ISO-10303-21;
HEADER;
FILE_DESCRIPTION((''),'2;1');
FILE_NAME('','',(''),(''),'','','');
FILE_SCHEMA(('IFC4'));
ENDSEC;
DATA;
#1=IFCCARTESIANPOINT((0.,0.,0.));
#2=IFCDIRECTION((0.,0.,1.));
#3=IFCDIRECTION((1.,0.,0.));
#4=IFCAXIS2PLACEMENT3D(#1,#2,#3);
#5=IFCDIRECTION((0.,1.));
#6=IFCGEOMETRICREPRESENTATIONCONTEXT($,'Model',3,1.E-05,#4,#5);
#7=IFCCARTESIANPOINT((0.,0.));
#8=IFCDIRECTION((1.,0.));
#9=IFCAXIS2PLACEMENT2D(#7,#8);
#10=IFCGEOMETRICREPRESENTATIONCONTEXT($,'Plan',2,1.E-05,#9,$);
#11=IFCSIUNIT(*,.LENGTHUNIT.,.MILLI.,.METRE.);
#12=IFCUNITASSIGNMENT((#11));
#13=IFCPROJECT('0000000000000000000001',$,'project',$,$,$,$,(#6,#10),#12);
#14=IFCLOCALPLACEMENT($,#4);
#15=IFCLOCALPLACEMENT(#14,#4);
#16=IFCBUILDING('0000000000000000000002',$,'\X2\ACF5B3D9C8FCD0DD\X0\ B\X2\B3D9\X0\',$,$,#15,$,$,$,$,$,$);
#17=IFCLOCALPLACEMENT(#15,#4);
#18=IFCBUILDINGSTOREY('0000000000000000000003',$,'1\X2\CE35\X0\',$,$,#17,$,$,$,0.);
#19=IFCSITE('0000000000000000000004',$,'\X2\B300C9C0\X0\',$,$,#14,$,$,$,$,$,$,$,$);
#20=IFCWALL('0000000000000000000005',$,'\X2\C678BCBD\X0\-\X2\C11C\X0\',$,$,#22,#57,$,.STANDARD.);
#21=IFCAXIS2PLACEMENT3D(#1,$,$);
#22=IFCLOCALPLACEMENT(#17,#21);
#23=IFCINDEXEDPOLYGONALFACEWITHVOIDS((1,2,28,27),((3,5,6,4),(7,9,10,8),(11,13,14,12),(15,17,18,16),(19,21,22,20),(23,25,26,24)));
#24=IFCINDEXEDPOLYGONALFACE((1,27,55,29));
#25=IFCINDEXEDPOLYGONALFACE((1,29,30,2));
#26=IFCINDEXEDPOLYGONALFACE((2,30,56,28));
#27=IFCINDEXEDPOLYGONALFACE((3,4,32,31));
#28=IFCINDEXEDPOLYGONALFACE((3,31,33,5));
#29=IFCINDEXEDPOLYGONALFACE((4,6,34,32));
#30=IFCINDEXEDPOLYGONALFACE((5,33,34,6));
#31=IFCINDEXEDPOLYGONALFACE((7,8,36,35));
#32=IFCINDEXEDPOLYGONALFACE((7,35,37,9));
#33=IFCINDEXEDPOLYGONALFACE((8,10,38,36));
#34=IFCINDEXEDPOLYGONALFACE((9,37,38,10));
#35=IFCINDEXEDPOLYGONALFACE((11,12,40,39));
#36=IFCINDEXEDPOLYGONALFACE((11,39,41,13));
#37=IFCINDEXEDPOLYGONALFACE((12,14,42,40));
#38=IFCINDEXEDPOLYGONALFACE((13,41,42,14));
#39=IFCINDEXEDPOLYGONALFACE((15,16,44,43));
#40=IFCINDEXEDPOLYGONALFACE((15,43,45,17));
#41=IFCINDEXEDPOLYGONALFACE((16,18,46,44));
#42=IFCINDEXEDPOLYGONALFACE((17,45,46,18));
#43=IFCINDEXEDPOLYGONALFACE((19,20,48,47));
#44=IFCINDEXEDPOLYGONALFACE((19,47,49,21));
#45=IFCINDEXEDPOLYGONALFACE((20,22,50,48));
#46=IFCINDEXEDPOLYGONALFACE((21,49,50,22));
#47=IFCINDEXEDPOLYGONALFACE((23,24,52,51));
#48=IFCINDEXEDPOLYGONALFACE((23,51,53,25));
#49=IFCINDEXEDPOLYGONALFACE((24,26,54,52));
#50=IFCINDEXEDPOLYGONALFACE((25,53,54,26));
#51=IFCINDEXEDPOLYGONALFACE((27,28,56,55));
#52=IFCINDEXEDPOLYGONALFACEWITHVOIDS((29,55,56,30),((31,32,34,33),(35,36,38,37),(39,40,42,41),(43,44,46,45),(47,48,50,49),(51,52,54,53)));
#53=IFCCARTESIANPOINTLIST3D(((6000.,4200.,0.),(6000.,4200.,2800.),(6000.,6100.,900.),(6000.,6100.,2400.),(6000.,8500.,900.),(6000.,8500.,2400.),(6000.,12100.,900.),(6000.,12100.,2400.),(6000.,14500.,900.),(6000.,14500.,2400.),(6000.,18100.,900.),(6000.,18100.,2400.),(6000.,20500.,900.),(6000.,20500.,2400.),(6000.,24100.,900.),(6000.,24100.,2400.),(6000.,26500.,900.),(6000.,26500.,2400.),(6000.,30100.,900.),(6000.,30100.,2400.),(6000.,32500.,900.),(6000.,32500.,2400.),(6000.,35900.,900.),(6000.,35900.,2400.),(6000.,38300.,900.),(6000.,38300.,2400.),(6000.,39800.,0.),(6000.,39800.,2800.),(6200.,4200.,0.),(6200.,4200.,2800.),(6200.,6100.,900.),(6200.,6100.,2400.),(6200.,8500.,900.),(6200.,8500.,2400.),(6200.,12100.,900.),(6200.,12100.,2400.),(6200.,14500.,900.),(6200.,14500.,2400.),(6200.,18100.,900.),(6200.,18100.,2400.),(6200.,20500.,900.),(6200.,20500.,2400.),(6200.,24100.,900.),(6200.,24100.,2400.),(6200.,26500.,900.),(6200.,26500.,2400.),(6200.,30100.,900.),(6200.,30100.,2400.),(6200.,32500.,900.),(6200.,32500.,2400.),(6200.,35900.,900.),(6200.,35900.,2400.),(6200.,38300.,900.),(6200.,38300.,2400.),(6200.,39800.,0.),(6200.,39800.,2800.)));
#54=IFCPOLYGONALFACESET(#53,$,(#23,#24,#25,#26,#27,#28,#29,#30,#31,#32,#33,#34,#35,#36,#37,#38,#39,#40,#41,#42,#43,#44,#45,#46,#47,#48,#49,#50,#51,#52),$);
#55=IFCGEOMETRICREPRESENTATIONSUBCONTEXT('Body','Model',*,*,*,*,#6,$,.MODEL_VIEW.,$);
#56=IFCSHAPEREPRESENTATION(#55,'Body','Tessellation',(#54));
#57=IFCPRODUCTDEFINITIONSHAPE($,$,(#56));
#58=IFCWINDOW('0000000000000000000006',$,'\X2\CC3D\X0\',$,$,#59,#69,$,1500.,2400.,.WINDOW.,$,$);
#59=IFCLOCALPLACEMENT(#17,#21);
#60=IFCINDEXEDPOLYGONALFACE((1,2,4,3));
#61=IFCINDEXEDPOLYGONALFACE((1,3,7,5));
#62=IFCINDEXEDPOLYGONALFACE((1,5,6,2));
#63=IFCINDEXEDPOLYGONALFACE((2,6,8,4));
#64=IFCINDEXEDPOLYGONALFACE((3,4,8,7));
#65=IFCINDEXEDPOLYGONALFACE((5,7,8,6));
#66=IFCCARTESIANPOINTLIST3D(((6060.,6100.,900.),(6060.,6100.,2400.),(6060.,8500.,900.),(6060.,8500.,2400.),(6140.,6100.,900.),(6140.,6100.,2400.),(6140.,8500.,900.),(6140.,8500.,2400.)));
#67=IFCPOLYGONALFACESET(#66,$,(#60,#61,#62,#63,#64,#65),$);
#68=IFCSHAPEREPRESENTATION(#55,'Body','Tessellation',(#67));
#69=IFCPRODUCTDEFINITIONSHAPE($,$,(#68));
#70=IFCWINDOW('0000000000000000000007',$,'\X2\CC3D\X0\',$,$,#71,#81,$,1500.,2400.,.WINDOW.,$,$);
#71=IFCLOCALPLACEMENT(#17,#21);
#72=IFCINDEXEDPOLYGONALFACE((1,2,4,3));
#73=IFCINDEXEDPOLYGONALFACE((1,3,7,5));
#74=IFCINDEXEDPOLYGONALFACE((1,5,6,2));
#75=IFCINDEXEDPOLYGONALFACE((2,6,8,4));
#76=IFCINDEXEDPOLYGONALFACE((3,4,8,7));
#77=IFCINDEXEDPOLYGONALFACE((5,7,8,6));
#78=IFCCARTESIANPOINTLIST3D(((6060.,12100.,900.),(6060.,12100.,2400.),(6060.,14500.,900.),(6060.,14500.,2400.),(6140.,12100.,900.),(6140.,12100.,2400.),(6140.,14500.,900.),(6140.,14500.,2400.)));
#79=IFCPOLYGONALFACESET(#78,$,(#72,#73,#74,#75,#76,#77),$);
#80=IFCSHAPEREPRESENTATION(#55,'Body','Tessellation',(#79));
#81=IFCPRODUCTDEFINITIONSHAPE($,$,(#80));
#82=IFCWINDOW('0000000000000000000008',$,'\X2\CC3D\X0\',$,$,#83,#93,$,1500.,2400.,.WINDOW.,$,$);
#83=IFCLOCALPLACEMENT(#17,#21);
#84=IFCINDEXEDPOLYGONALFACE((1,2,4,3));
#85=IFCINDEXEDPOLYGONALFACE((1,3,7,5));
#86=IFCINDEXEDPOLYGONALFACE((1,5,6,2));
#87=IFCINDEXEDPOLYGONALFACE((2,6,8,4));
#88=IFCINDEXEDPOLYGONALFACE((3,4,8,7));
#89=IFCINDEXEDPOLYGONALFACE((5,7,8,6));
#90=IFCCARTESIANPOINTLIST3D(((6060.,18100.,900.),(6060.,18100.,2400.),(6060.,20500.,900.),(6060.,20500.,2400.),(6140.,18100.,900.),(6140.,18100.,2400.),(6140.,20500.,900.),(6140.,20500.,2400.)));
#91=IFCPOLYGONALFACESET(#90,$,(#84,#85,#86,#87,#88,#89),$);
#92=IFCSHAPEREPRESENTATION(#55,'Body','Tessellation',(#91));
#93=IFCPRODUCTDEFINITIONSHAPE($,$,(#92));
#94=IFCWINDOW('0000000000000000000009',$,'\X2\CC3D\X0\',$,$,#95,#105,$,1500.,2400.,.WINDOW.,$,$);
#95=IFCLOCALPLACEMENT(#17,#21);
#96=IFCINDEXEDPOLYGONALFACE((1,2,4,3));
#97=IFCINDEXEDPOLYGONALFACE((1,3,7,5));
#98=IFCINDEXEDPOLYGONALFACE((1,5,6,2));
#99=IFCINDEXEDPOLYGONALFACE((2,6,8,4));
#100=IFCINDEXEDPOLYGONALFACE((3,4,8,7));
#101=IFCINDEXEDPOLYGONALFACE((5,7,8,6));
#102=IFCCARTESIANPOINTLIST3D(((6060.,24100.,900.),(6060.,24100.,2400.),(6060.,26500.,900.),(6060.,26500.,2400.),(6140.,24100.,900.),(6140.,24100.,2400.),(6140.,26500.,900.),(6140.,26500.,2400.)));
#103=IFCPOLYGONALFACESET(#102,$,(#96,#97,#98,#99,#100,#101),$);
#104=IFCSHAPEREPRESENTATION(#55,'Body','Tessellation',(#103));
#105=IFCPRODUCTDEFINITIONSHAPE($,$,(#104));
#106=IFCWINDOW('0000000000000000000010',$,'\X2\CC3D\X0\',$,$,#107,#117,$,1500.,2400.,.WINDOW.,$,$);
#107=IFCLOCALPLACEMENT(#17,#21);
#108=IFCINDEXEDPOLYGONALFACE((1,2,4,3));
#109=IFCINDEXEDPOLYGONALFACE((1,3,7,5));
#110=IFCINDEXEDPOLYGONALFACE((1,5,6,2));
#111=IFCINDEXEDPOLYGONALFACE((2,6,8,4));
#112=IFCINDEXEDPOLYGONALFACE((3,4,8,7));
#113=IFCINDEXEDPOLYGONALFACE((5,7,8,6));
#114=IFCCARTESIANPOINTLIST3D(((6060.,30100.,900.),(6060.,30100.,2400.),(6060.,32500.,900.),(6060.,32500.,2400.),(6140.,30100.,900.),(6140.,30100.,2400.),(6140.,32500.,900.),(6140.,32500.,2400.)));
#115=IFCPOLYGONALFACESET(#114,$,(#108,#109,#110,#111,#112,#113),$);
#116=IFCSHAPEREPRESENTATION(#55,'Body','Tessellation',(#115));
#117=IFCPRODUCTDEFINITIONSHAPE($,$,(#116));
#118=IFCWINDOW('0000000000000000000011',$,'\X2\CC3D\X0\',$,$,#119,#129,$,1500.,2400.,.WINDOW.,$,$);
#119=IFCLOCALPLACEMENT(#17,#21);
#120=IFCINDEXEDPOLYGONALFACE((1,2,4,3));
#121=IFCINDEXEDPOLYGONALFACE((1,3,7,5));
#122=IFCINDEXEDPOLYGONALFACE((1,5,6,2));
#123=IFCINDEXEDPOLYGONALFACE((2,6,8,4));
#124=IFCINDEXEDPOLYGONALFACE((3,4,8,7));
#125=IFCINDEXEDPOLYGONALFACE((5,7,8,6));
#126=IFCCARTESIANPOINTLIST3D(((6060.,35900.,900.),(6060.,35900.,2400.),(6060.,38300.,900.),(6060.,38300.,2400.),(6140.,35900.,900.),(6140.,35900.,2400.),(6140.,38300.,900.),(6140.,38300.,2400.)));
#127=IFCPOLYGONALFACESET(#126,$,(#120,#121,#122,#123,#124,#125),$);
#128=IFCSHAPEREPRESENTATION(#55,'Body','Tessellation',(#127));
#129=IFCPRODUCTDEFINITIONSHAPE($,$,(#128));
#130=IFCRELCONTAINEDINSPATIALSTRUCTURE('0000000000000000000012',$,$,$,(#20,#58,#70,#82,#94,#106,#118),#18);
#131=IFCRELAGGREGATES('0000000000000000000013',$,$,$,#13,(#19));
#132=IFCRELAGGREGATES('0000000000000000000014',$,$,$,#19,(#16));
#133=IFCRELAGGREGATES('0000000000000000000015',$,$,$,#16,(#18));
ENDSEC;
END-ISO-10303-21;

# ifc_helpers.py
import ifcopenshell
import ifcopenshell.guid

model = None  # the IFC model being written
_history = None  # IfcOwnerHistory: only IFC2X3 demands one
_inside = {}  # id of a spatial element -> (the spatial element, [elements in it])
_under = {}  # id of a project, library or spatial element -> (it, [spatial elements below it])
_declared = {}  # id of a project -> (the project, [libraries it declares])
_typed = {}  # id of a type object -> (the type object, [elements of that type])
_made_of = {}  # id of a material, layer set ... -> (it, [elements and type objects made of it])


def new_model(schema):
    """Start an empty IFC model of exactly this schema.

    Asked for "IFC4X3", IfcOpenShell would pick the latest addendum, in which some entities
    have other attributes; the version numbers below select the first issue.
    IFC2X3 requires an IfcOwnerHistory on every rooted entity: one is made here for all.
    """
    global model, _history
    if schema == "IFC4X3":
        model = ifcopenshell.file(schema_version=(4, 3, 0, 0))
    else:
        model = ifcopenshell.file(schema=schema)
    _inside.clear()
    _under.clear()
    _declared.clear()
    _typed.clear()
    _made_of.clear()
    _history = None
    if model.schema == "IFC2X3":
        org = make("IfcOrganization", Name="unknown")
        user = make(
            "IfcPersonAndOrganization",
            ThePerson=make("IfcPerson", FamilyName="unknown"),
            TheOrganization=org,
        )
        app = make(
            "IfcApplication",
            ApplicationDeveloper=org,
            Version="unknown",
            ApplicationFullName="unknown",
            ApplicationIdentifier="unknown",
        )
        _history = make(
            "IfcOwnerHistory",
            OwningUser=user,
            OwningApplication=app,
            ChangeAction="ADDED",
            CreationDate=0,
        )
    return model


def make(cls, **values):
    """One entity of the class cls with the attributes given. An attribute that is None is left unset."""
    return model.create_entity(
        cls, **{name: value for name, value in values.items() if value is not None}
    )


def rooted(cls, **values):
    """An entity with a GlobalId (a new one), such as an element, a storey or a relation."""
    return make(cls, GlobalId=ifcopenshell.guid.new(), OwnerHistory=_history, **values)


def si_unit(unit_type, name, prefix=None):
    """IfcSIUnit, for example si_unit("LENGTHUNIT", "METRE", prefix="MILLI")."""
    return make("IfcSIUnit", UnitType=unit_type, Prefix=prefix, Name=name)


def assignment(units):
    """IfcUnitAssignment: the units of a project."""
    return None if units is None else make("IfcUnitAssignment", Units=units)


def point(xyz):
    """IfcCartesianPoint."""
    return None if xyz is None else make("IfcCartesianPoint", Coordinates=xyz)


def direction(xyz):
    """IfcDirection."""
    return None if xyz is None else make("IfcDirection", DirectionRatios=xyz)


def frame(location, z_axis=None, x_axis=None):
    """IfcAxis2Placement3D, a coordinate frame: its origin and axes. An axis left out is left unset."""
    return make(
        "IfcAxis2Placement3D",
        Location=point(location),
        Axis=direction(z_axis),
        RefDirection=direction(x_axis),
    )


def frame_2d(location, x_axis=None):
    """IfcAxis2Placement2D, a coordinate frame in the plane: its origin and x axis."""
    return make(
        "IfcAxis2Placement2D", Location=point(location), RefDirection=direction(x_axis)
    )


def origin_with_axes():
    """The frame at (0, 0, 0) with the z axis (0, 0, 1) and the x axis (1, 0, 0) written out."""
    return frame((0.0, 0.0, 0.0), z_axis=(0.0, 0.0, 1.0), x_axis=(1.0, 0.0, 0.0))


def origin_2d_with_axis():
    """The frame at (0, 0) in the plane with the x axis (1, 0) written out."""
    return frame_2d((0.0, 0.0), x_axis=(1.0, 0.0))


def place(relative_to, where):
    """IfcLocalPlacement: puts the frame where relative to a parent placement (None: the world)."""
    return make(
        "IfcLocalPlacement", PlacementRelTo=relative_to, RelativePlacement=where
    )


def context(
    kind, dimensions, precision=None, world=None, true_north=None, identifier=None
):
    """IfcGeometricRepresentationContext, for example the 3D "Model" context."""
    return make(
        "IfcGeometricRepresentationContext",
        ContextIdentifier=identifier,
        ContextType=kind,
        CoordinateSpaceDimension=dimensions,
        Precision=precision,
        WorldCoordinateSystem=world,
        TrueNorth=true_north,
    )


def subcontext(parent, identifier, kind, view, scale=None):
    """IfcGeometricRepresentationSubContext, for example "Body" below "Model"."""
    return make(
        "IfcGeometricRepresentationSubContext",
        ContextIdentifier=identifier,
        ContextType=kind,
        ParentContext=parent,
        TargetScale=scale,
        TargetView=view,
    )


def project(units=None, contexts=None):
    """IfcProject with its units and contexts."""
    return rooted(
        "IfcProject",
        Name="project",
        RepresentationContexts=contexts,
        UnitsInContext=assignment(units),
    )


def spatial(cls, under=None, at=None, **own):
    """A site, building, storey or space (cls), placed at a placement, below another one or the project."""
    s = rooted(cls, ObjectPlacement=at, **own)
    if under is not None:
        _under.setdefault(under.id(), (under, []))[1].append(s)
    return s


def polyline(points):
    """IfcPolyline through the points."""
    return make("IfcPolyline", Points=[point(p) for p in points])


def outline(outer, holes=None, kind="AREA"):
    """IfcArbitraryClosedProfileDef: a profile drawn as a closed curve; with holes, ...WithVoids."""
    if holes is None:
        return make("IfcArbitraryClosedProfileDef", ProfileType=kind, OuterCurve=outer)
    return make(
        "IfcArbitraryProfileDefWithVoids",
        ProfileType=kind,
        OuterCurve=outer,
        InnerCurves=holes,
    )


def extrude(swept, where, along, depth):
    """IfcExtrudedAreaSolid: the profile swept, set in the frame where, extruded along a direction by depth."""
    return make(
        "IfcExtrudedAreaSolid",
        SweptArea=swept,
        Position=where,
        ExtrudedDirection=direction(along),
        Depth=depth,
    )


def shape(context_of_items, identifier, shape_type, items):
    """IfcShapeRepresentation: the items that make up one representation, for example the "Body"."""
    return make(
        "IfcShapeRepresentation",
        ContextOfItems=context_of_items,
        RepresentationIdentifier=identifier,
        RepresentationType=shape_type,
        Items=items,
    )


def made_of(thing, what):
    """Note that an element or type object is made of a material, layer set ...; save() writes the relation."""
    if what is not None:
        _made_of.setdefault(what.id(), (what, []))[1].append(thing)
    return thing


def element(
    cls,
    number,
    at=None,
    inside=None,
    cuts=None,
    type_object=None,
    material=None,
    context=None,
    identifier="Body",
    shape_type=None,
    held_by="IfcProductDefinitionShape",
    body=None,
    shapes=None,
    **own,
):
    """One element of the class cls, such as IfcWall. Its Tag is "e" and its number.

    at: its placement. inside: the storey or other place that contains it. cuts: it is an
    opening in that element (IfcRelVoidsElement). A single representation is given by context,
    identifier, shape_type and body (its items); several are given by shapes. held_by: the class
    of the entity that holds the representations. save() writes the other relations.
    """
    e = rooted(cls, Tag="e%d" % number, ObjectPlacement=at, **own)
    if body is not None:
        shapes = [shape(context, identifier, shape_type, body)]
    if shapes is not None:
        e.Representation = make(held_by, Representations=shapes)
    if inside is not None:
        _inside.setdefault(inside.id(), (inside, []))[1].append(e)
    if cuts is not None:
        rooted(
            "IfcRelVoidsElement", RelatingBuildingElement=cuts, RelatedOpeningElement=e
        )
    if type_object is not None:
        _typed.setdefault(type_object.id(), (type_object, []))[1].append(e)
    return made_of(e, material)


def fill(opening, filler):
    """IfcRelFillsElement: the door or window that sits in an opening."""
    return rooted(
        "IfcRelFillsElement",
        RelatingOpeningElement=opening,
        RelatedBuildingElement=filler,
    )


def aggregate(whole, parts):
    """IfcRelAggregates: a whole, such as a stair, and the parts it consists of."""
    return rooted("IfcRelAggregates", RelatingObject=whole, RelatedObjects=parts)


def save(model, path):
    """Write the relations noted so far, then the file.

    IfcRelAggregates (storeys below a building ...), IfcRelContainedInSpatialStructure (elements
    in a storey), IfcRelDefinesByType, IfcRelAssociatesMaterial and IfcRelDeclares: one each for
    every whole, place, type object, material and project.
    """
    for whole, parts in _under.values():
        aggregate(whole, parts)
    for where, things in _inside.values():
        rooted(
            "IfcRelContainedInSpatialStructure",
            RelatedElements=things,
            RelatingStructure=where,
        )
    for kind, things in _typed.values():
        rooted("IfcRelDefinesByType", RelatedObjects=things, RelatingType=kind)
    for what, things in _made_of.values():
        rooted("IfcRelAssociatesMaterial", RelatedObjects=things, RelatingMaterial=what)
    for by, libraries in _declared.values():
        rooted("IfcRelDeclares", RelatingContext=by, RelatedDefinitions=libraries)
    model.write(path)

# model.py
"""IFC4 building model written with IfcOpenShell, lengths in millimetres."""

from ifc_helpers import new_model, si_unit, direction, frame, origin_with_axes, origin_2d_with_axis, place, context, subcontext, project, spatial, polyline, outline, extrude, element, fill, save


model = new_model("IFC4")

# Units and contexts
model_context = context("Model", 3, precision=1e-05, world=origin_with_axes(), true_north=direction((0.0, 1.0)))
plan_context = context("Plan", 2, precision=1e-05, world=origin_2d_with_axis())
body_context = subcontext(model_context, "Body", "Model", "MODEL_VIEW")
ifc_project = project(units=[si_unit("LENGTHUNIT", "METRE", prefix="MILLI")], contexts=[model_context, plan_context])

# Site, building, storey
site_placement = place(None, origin_with_axes())
site = spatial("IfcSite", under=ifc_project, at=site_placement, Name="대지")
building_placement = place(site_placement, origin_with_axes())
building = spatial("IfcBuilding", under=site, at=building_placement, Name="공동주택 B동")
storey_placement = place(building_placement, origin_with_axes())
storey = spatial("IfcBuildingStorey", under=building, at=storey_placement, Name="1층", Elevation=0.0)

# Wall, openings, windows
wall_1_placement = place(storey_placement, origin_with_axes())
wall_1 = element("IfcWall", 1, at=wall_1_placement, inside=storey, Name="외벽-서", PredefinedType="STANDARD", context=body_context, shape_type="SweptSolid", body=[
    extrude(outline(polyline([(6200.0, 39800.0), (6200.0, 4200.0), (6000.0, 4200.0), (6000.0, 39800.0), (6200.0, 39800.0)])), origin_with_axes(), (0.0, 0.0, 1.0), 2800.0),
])
opening_1_placement = place(storey_placement, origin_with_axes())
opening_1 = element("IfcOpeningElement", 2, at=opening_1_placement, cuts=wall_1, PredefinedType="OPENING", context=body_context, shape_type="SweptSolid", body=[
    extrude(outline(polyline([(5950.0, 8500.0), (5950.0, 6100.0), (6250.0, 6100.0), (6250.0, 8500.0), (5950.0, 8500.0)])), frame((0.0, 0.0, 900.0), z_axis=(0.0, 0.0, 1.0), x_axis=(1.0, 0.0, 0.0)), (0.0, 0.0, 1.0), 1500.0),
])
opening_2_placement = place(storey_placement, origin_with_axes())
opening_2 = element("IfcOpeningElement", 3, at=opening_2_placement, cuts=wall_1, PredefinedType="OPENING", context=body_context, shape_type="SweptSolid", body=[
    extrude(outline(polyline([(5950.0, 14500.0), (5950.0, 12100.0), (6250.0, 12100.0), (6250.0, 14500.0), (5950.0, 14500.0)])), frame((0.0, 0.0, 900.0), z_axis=(0.0, 0.0, 1.0), x_axis=(1.0, 0.0, 0.0)), (0.0, 0.0, 1.0), 1500.0),
])
opening_3_placement = place(storey_placement, origin_with_axes())
opening_3 = element("IfcOpeningElement", 4, at=opening_3_placement, cuts=wall_1, PredefinedType="OPENING", context=body_context, shape_type="SweptSolid", body=[
    extrude(outline(polyline([(5950.0, 20500.0), (5950.0, 18100.0), (6250.0, 18100.0), (6250.0, 20500.0), (5950.0, 20500.0)])), frame((0.0, 0.0, 900.0), z_axis=(0.0, 0.0, 1.0), x_axis=(1.0, 0.0, 0.0)), (0.0, 0.0, 1.0), 1500.0),
])
opening_4_placement = place(storey_placement, origin_with_axes())
opening_4 = element("IfcOpeningElement", 5, at=opening_4_placement, cuts=wall_1, PredefinedType="OPENING", context=body_context, shape_type="SweptSolid", body=[
    extrude(outline(polyline([(5950.0, 26500.0), (5950.0, 24100.0), (6250.0, 24100.0), (6250.0, 26500.0), (5950.0, 26500.0)])), frame((0.0, 0.0, 900.0), z_axis=(0.0, 0.0, 1.0), x_axis=(1.0, 0.0, 0.0)), (0.0, 0.0, 1.0), 1500.0),
])
opening_5_placement = place(storey_placement, origin_with_axes())
opening_5 = element("IfcOpeningElement", 6, at=opening_5_placement, cuts=wall_1, PredefinedType="OPENING", context=body_context, shape_type="SweptSolid", body=[
    extrude(outline(polyline([(5950.0, 32500.0), (5950.0, 30100.0), (6250.0, 30100.0), (6250.0, 32500.0), (5950.0, 32500.0)])), frame((0.0, 0.0, 900.0), z_axis=(0.0, 0.0, 1.0), x_axis=(1.0, 0.0, 0.0)), (0.0, 0.0, 1.0), 1500.0),
])
opening_6_placement = place(storey_placement, origin_with_axes())
opening_6 = element("IfcOpeningElement", 7, at=opening_6_placement, cuts=wall_1, PredefinedType="OPENING", context=body_context, shape_type="SweptSolid", body=[
    extrude(outline(polyline([(5950.0, 38300.0), (5950.0, 35900.0), (6250.0, 35900.0), (6250.0, 38300.0), (5950.0, 38300.0)])), frame((0.0, 0.0, 900.0), z_axis=(0.0, 0.0, 1.0), x_axis=(1.0, 0.0, 0.0)), (0.0, 0.0, 1.0), 1500.0),
])
window_1_placement = place(storey_placement, origin_with_axes())
window_1 = element("IfcWindow", 8, at=window_1_placement, inside=storey, Name="창", OverallHeight=1500.0, OverallWidth=2400.0, PredefinedType="WINDOW", context=body_context, shape_type="SweptSolid", body=[
    extrude(outline(polyline([(6060.0, 8500.0), (6060.0, 6100.0), (6140.0, 6100.0), (6140.0, 8500.0), (6060.0, 8500.0)])), frame((0.0, 0.0, 900.0), z_axis=(0.0, 0.0, 1.0), x_axis=(1.0, 0.0, 0.0)), (0.0, 0.0, 1.0), 1500.0),
])
fill(opening_1, window_1)
window_2_placement = place(storey_placement, origin_with_axes())
window_2 = element("IfcWindow", 9, at=window_2_placement, inside=storey, Name="창", OverallHeight=1500.0, OverallWidth=2400.0, PredefinedType="WINDOW", context=body_context, shape_type="SweptSolid", body=[
    extrude(outline(polyline([(6060.0, 14500.0), (6060.0, 12100.0), (6140.0, 12100.0), (6140.0, 14500.0), (6060.0, 14500.0)])), frame((0.0, 0.0, 900.0), z_axis=(0.0, 0.0, 1.0), x_axis=(1.0, 0.0, 0.0)), (0.0, 0.0, 1.0), 1500.0),
])
fill(opening_2, window_2)
window_3_placement = place(storey_placement, origin_with_axes())
window_3 = element("IfcWindow", 10, at=window_3_placement, inside=storey, Name="창", OverallHeight=1500.0, OverallWidth=2400.0, PredefinedType="WINDOW", context=body_context, shape_type="SweptSolid", body=[
    extrude(outline(polyline([(6060.0, 20500.0), (6060.0, 18100.0), (6140.0, 18100.0), (6140.0, 20500.0), (6060.0, 20500.0)])), frame((0.0, 0.0, 900.0), z_axis=(0.0, 0.0, 1.0), x_axis=(1.0, 0.0, 0.0)), (0.0, 0.0, 1.0), 1500.0),
])
fill(opening_3, window_3)
window_4_placement = place(storey_placement, origin_with_axes())
window_4 = element("IfcWindow", 11, at=window_4_placement, inside=storey, Name="창", OverallHeight=1500.0, OverallWidth=2400.0, PredefinedType="WINDOW", context=body_context, shape_type="SweptSolid", body=[
    extrude(outline(polyline([(6060.0, 26500.0), (6060.0, 24100.0), (6140.0, 24100.0), (6140.0, 26500.0), (6060.0, 26500.0)])), frame((0.0, 0.0, 900.0), z_axis=(0.0, 0.0, 1.0), x_axis=(1.0, 0.0, 0.0)), (0.0, 0.0, 1.0), 1500.0),
])
fill(opening_4, window_4)
window_5_placement = place(storey_placement, origin_with_axes())
window_5 = element("IfcWindow", 12, at=window_5_placement, inside=storey, Name="창", OverallHeight=1500.0, OverallWidth=2400.0, PredefinedType="WINDOW", context=body_context, shape_type="SweptSolid", body=[
    extrude(outline(polyline([(6060.0, 32500.0), (6060.0, 30100.0), (6140.0, 30100.0), (6140.0, 32500.0), (6060.0, 32500.0)])), frame((0.0, 0.0, 900.0), z_axis=(0.0, 0.0, 1.0), x_axis=(1.0, 0.0, 0.0)), (0.0, 0.0, 1.0), 1500.0),
])
fill(opening_5, window_5)
window_6_placement = place(storey_placement, origin_with_axes())
window_6 = element("IfcWindow", 13, at=window_6_placement, inside=storey, Name="창", OverallHeight=1500.0, OverallWidth=2400.0, PredefinedType="WINDOW", context=body_context, shape_type="SweptSolid", body=[
    extrude(outline(polyline([(6060.0, 38300.0), (6060.0, 35900.0), (6140.0, 35900.0), (6140.0, 38300.0), (6060.0, 38300.0)])), frame((0.0, 0.0, 900.0), z_axis=(0.0, 0.0, 1.0), x_axis=(1.0, 0.0, 0.0)), (0.0, 0.0, 1.0), 1500.0),
])
fill(opening_6, window_6)

save(model, "model.ifc")
